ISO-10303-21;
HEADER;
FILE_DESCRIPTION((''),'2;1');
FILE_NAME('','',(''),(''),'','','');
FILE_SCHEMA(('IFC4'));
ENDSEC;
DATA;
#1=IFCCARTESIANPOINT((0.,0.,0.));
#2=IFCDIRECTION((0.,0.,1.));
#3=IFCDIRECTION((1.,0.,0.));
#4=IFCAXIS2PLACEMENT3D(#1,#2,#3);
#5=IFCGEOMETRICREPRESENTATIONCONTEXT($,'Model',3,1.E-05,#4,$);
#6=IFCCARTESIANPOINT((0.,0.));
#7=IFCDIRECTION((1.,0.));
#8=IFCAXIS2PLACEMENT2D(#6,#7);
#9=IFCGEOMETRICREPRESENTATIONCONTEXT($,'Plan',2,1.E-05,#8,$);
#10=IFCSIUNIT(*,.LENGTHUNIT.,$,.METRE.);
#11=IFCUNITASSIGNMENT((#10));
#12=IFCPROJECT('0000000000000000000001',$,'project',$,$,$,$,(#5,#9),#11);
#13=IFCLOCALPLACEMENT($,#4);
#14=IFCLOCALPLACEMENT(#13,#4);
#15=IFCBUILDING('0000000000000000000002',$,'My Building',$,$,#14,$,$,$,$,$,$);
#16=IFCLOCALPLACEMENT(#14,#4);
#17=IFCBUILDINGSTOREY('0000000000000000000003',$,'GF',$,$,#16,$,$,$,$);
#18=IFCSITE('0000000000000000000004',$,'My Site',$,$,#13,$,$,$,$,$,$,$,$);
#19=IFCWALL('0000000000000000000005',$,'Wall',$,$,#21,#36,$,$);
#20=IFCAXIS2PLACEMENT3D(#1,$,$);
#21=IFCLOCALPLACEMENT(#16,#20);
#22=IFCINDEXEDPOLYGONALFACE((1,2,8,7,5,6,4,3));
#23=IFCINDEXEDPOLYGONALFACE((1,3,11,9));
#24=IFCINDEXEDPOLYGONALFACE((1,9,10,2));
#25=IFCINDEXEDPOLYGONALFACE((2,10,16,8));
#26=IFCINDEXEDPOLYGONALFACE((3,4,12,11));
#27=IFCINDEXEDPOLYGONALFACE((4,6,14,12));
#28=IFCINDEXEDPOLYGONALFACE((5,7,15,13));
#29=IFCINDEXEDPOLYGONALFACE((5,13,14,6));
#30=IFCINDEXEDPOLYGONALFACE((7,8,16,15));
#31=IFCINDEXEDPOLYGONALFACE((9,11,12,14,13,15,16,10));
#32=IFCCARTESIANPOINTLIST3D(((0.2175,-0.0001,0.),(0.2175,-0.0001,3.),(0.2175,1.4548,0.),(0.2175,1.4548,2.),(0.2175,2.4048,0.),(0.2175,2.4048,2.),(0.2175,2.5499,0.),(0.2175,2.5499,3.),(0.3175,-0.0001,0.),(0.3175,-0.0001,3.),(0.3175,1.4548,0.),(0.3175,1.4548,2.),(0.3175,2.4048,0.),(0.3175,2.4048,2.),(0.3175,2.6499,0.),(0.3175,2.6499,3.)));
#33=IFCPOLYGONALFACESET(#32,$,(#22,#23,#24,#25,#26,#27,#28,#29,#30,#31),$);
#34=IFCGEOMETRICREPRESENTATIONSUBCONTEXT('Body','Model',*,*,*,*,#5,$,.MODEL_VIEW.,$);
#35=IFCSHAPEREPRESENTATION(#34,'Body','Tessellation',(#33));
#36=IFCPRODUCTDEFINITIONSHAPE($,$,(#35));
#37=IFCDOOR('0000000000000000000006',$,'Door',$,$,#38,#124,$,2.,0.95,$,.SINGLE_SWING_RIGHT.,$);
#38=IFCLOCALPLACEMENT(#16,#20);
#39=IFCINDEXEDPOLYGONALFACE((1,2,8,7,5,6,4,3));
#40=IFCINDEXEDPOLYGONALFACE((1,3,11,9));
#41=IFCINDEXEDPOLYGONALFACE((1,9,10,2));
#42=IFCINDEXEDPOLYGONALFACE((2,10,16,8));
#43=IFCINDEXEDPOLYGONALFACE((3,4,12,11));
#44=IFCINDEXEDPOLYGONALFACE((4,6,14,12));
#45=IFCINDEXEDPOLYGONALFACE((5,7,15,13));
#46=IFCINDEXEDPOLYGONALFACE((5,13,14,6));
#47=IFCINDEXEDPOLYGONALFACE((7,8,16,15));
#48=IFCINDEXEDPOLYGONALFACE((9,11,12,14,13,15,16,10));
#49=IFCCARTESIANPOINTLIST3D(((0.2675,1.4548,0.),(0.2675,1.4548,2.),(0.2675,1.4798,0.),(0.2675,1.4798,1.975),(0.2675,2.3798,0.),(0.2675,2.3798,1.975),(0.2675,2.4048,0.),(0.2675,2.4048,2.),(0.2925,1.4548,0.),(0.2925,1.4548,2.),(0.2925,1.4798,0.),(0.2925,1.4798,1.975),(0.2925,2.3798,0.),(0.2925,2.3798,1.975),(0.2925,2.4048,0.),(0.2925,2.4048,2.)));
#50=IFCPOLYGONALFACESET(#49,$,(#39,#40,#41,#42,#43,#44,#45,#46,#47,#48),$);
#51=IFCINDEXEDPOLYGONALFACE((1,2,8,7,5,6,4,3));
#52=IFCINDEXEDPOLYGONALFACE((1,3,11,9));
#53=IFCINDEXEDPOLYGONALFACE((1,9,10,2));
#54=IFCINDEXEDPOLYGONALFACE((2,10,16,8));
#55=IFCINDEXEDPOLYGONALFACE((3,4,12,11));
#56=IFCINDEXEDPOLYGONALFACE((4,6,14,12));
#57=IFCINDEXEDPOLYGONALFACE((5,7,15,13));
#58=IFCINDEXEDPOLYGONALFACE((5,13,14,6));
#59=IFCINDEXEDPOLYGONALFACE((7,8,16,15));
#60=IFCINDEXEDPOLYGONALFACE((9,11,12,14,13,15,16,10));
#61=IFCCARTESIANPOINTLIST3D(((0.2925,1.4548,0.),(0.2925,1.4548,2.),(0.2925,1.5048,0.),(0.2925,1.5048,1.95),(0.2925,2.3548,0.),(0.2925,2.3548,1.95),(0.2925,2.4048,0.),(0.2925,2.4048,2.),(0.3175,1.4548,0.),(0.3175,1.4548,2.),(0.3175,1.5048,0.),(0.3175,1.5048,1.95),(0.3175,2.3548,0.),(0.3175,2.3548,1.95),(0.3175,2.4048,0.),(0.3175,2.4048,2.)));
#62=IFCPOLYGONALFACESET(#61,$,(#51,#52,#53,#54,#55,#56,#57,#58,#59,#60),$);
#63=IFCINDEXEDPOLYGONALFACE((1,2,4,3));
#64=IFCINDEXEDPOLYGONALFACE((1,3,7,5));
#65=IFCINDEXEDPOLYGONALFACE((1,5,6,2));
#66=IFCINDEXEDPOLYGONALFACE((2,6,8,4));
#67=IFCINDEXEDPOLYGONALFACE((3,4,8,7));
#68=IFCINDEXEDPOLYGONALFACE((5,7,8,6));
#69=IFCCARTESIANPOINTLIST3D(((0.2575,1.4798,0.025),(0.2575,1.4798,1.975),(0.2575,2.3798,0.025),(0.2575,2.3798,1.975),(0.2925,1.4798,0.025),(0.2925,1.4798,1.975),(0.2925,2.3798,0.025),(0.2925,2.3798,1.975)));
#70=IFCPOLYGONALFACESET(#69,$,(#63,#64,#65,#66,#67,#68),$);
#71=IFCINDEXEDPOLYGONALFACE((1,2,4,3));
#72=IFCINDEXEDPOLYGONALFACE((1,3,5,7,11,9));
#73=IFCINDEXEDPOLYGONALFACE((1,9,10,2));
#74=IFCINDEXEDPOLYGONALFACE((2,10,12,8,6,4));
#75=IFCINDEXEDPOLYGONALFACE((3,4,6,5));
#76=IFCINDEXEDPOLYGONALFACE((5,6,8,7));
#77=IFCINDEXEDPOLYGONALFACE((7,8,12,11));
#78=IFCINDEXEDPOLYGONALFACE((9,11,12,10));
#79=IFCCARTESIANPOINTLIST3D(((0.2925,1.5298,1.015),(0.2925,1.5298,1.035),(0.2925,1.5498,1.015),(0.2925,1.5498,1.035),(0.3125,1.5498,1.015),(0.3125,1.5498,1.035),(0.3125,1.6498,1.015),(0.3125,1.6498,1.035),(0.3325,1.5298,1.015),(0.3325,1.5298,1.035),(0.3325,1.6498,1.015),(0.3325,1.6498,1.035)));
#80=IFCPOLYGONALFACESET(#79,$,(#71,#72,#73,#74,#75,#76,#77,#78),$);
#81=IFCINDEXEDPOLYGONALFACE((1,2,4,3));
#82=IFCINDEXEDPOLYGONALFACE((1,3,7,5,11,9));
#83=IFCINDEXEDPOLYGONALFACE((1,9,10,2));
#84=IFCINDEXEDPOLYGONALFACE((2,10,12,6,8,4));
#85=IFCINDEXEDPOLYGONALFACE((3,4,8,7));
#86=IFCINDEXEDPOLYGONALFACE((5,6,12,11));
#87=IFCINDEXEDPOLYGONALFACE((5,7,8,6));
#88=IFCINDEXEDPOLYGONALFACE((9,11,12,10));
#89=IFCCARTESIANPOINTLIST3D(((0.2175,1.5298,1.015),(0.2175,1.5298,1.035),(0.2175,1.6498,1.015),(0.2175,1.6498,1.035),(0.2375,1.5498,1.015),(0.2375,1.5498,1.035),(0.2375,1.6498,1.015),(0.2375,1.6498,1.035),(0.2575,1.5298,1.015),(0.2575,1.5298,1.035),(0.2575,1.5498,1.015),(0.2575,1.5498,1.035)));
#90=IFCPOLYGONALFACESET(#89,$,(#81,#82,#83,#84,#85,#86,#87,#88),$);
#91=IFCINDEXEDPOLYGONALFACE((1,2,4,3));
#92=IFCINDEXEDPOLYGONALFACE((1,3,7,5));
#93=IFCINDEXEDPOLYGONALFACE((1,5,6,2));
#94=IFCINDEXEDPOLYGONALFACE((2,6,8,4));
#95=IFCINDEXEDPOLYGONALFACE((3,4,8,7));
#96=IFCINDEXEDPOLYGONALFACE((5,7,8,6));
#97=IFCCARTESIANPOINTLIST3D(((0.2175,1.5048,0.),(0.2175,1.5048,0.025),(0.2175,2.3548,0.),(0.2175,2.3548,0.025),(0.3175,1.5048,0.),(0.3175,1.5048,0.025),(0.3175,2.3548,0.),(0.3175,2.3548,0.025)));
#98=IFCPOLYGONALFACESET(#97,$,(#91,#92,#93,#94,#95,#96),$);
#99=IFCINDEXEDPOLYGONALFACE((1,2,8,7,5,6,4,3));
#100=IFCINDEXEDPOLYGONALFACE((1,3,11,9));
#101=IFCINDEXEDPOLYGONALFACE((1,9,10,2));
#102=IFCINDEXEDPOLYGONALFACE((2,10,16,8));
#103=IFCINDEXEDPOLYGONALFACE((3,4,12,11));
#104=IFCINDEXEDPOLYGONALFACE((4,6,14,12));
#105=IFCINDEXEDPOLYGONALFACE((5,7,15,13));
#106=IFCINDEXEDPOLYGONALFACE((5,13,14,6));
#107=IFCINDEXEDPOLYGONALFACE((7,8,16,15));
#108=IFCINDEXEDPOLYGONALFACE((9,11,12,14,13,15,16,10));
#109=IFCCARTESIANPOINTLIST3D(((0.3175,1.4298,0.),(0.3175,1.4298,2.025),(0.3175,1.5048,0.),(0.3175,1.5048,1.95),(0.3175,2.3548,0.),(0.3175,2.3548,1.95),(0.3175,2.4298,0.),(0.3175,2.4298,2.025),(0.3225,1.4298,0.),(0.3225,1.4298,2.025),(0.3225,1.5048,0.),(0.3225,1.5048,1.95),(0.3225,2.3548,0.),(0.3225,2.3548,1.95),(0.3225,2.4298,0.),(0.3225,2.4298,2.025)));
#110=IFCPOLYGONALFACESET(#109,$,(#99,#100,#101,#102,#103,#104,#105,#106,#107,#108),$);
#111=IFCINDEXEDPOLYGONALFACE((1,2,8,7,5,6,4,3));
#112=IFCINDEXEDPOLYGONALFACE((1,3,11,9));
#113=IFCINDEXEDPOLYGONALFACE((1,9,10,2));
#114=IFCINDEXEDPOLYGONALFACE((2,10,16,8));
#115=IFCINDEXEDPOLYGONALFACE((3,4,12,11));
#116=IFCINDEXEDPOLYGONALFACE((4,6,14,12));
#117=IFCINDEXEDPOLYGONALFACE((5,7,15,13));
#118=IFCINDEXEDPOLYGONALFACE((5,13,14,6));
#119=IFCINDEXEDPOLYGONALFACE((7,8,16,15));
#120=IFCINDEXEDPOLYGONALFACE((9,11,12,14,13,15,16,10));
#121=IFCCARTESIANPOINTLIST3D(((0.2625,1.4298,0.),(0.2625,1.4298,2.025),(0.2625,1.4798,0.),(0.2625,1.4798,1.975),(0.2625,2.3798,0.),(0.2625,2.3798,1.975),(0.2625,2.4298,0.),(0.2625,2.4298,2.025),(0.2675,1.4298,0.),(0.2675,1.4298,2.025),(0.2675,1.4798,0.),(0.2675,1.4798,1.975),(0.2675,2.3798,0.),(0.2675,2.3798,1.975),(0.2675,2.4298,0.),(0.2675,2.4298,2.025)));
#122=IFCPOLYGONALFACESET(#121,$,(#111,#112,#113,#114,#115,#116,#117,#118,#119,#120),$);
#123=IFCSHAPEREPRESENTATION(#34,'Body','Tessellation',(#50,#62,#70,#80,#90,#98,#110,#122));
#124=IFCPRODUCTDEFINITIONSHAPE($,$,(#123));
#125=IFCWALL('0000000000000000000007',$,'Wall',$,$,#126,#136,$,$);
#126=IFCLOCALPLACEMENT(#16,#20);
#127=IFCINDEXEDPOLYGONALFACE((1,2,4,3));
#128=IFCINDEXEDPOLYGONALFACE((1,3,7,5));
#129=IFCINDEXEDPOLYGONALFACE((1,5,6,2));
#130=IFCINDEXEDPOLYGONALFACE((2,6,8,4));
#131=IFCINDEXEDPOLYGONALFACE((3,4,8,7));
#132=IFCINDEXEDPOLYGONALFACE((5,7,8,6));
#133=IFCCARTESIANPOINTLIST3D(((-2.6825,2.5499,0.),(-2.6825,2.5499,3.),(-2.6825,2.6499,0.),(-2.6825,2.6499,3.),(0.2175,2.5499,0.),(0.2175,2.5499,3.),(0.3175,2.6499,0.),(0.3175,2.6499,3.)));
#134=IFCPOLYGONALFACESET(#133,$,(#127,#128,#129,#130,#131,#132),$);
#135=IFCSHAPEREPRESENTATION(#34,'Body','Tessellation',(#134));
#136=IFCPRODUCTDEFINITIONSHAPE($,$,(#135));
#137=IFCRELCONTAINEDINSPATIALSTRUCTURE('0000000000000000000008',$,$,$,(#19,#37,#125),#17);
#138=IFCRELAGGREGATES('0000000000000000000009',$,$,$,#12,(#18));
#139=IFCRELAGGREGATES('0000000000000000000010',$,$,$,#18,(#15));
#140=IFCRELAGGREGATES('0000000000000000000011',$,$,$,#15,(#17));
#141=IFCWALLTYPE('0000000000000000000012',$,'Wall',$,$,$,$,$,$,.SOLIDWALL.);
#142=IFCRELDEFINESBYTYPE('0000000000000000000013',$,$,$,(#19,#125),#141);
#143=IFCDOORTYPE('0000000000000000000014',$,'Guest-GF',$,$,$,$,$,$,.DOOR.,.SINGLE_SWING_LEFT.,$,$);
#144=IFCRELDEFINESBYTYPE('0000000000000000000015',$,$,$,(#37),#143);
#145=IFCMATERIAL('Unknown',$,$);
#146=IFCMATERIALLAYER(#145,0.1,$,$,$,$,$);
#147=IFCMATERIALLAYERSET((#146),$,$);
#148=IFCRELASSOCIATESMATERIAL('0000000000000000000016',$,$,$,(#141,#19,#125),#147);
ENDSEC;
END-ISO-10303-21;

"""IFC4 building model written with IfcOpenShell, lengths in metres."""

from ifc_helpers import new_model, entity, si_unit, frame, origin_with_axes, origin_2d_with_axis, place, context, subcontext, project, spatial, line, indexed_curve, outline, extrude, shape, source, transform, mapped, material, layer, layer_set, layer_usage, type_object, type_shapes, element, fill, save


model = new_model("IFC4")

# Units and contexts
model_context = context("Model", 3, precision=1e-05, world=origin_with_axes())
plan_context = context("Plan", 2, precision=1e-05, world=origin_2d_with_axis())
body_context_1 = subcontext(model_context, "Body", "Model", "MODEL_VIEW")
body_context_2 = subcontext(plan_context, "Body", "Plan", "PLAN_VIEW")
ifc_project = project(units=[si_unit("LENGTHUNIT", "METRE")], contexts=[model_context, plan_context])

# Site, building, storey
site_placement = place(None, origin_with_axes())
site = spatial("IfcSite", under=ifc_project, at=site_placement, Name="My Site")
building_placement = place(site_placement, origin_with_axes())
building = spatial("IfcBuilding", under=site, at=building_placement, Name="My Building")
storey_placement = place(building_placement, origin_with_axes())
storey = spatial("IfcBuildingStorey", under=building, at=storey_placement, Name="GF")

# Shared definitions
ifc_material_1 = material(Name="Unknown")

# Shared definitions
ifc_layer_1 = layer(ifc_material_1, 0.1)
ifc_layer_set_1 = layer_set([ifc_layer_1])
wall_type = type_object("IfcWallType", Name="Wall", PredefinedType="SOLIDWALL", material=ifc_layer_set_1)

# Wall, opening, door
ifc_layer_usage_1 = layer_usage(ifc_layer_set_1, "AXIS2", "POSITIVE", 0.0)
wall_1_placement = place(storey_placement, frame((0.3175, -0.0001, 0.0), z_axis=(0.0, 0.0, 1.0), x_axis=(0.0, 1.0, 0.0)))
wall_1 = element("IfcWall", 1, at=wall_1_placement, inside=storey, type_object=wall_type, material=ifc_layer_usage_1, Name="Wall", context=body_context_1, shape_type="SweptSolid", body=[
    extrude(outline(indexed_curve([(0.0, 0.0), (0.0, 0.1), (2.55, 0.1), (2.65, 0.0)], segments=[line(1, 2, 3, 4, 1)])), origin_with_axes(), (0.0, 0.0, 1.0), 3.0),
])
shared_shape_1 = source(origin_with_axes(), body_context_1, "Body", "SweptSolid", [
    extrude(outline(indexed_curve([(0.0, 0.0), (0.95, 0.0), (0.95, 2.0), (0.0, 2.0)], segments=[line(1, 2, 3, 4, 1)])), frame((0.0, -0.6, 0.0), z_axis=(0.0, -1.0, 0.0), x_axis=(1.0, 0.0, 0.0)), (0.0, 0.0, -1.0), 1.2),
])
opening_1_placement = place(wall_1_placement, frame((1.4549, 0.0, 0.0), z_axis=(0.0, 0.0, 1.0), x_axis=(1.0, 0.0, 0.0)))
opening_1 = element("IfcOpeningElement", 2, at=opening_1_placement, cuts=wall_1, PredefinedType="OPENING", context=body_context_1, shape_type="MappedRepresentation", body=[
    mapped(shared_shape_1, transform((0.0, 0.0, 0.0), x_axis=(1.0, 0.0, 0.0), y_axis=(0.0, 1.0, 0.0), z_axis=(0.0, 0.0, 1.0), scale=1.0)),
])
door_type_1 = type_object("IfcDoorType", Name="Guest-GF", OperationType="SINGLE_SWING_LEFT", PredefinedType="DOOR")
shared_shape_2 = source(origin_with_axes(), body_context_1, "Body", "SweptSolid", [
    extrude(outline(indexed_curve([(0.0, 0.0), (0.0, 2.0), (0.95, 2.0), (0.95, 0.0), (0.925, 0.0), (0.925, 1.975), (0.025, 1.975), (0.025, 0.0)], segments=[line(1, 2, 3, 4, 5, 6, 7, 8, 1)])), frame((0.0, 0.025, 0.0), z_axis=(0.0, -1.0, 0.0), x_axis=(1.0, 0.0, 0.0)), (0.0, 0.0, -1.0), 0.025),
    extrude(outline(indexed_curve([(0.0, 0.0), (0.0, 2.0), (0.95, 2.0), (0.95, 0.0), (0.9, 0.0), (0.9, 1.95), (0.05, 1.95), (0.05, 0.0)], segments=[line(1, 2, 3, 4, 5, 6, 7, 8, 1)])), frame((0.0, 0.0, 0.0), z_axis=(0.0, -1.0, 0.0), x_axis=(1.0, 0.0, 0.0)), (0.0, 0.0, -1.0), 0.025),
    extrude(outline(indexed_curve([(0.0, 0.0), (0.9, 0.0), (0.9, 0.035), (0.0, 0.035)], segments=[line(1, 2, 3, 4, 1)])), frame((0.025, 0.025, 0.025), z_axis=(0.0, 0.0, 1.0), x_axis=(1.0, 0.0, 0.0)), (0.0, 0.0, 1.0), 1.95),
    extrude(outline(indexed_curve([(0.0, 0.0), (0.0, -0.04), (0.12, -0.04), (0.12, -0.02), (0.02, -0.02), (0.02, 0.0)], segments=[line(1, 2, 3, 4, 5, 6, 1)])), frame((0.075, 0.025, 1.015), z_axis=(0.0, 0.0, 1.0), x_axis=(1.0, 0.0, 0.0)), (0.0, 0.0, 1.0), 0.02),
    extrude(outline(indexed_curve([(0.0, 0.0), (0.0, 0.04), (0.12, 0.04), (0.12, 0.02), (0.02, 0.02), (0.02, 0.0)], segments=[line(1, 2, 3, 4, 5, 6, 1)])), frame((0.075, 0.06, 1.015), z_axis=(0.0, 0.0, 1.0), x_axis=(1.0, 0.0, 0.0)), (0.0, 0.0, 1.0), 0.02),
    extrude(outline(indexed_curve([(0.0, 0.0), (0.85, 0.0), (0.85, 0.1), (0.0, 0.1)], segments=[line(1, 2, 3, 4, 1)])), frame((0.05, 0.0, 0.0), z_axis=(0.0, 0.0, 1.0), x_axis=(1.0, 0.0, 0.0)), (0.0, 0.0, 1.0), 0.025),
    extrude(outline(indexed_curve([(0.0, 0.0), (0.0, 2.025), (1.0, 2.025), (1.0, 0.0), (0.925, 0.0), (0.925, 1.95), (0.075, 1.95), (0.075, 0.0)], segments=[line(1, 2, 3, 4, 5, 6, 7, 8, 1)])), frame((-0.025, -0.005, 0.0), z_axis=(0.0, -1.0, 0.0), x_axis=(1.0, 0.0, 0.0)), (0.0, 0.0, -1.0), 0.005),
    extrude(outline(indexed_curve([(0.0, 0.0), (0.0, 2.025), (1.0, 2.025), (1.0, 0.0), (0.95, 0.0), (0.95, 1.975), (0.05, 1.975), (0.05, 0.0)], segments=[line(1, 2, 3, 4, 5, 6, 7, 8, 1)])), frame((-0.025, 0.05, 0.0), z_axis=(0.0, -1.0, 0.0), x_axis=(1.0, 0.0, 0.0)), (0.0, 0.0, -1.0), 0.005),
])
shared_shape_3 = source(origin_with_axes(), body_context_2, "Body", "Curve2D", [
    entity("IfcIndexedPolyCurve", entity("IfcCartesianPointList2D", [[0.0, 0.0], [0.0, 0.05], [0.025, 0.05], [0.025, 0.025], [0.05, 0.025], [0.05, 0.0]]), [entity("IfcLineIndex", [1, 2, 3, 4, 5, 6, 1])]),
    entity("IfcIndexedPolyCurve", entity("IfcCartesianPointList2D", [[0.95, 0.0], [0.95, 0.05], [0.925, 0.05], [0.925, 0.025], [0.9, 0.025], [0.9, 0.0]]), [entity("IfcLineIndex", [1, 2, 3, 4, 5, 6, 1])]),
    entity("IfcTrimmedCurve", entity("IfcEllipse", entity("IfcAxis2Placement2D", entity("IfcCartesianPoint", [0.89, 0.05]), entity("IfcDirection", [1.0, 0.0])), 0.865, 0.9), [entity("IfcCartesianPoint", [0.89, 0.95])], [entity("IfcCartesianPoint", [0.025, 0.05])], True, "CARTESIAN"),
    entity("IfcIndexedPolyCurve", entity("IfcCartesianPointList2D", [[0.925, 0.05], [0.89, 0.05], [0.89, 0.95], [0.925, 0.95]]), [entity("IfcLineIndex", [1, 2, 3, 4, 1])]),
])
type_shapes(door_type_1, [shared_shape_2, shared_shape_3])
door_1_placement = place(opening_1_placement, frame((0.0, 0.0, 0.0), z_axis=(0.0, 0.0, 1.0), x_axis=(1.0, 0.0, 0.0)))
door_1 = element("IfcDoor", 3, at=door_1_placement, inside=storey, type_object=door_type_1, Name="Door", OperationType="SINGLE_SWING_RIGHT", OverallHeight=2.0, OverallWidth=0.95, shapes=[
    shape(body_context_1, "Body", "MappedRepresentation", [mapped(shared_shape_2, transform((0.0, 0.0, 0.0), x_axis=(1.0, 0.0, 0.0), y_axis=(0.0, 1.0, 0.0), z_axis=(0.0, 0.0, 1.0), scale=1.0))]),
    shape(body_context_2, "Body", "MappedRepresentation", [mapped(shared_shape_3, transform((0.0, 0.0, 0.0), x_axis=(1.0, 0.0, 0.0), y_axis=(0.0, 1.0, 0.0), z_axis=(0.0, 0.0, 1.0), scale=1.0))]),
])
fill(opening_1, door_1)

# Wall
ifc_layer_usage_2 = layer_usage(ifc_layer_set_1, "AXIS2", "POSITIVE", 0.0)
wall_2_placement = place(storey_placement, frame((0.3175, 2.6499, 0.0), z_axis=(0.0, 0.0, 1.0), x_axis=(-1.0, 0.0, 0.0)))
element("IfcWall", 4, at=wall_2_placement, inside=storey, type_object=wall_type, material=ifc_layer_usage_2, Name="Wall", context=body_context_1, shape_type="SweptSolid", body=[
    extrude(outline(indexed_curve([(0.0, 0.0), (0.1, 0.1), (3.0, 0.1), (3.0, 0.0)], segments=[line(1, 2, 3, 4, 1)])), origin_with_axes(), (0.0, 0.0, 1.0), 3.0),
])

save(model, "model.ifc")
